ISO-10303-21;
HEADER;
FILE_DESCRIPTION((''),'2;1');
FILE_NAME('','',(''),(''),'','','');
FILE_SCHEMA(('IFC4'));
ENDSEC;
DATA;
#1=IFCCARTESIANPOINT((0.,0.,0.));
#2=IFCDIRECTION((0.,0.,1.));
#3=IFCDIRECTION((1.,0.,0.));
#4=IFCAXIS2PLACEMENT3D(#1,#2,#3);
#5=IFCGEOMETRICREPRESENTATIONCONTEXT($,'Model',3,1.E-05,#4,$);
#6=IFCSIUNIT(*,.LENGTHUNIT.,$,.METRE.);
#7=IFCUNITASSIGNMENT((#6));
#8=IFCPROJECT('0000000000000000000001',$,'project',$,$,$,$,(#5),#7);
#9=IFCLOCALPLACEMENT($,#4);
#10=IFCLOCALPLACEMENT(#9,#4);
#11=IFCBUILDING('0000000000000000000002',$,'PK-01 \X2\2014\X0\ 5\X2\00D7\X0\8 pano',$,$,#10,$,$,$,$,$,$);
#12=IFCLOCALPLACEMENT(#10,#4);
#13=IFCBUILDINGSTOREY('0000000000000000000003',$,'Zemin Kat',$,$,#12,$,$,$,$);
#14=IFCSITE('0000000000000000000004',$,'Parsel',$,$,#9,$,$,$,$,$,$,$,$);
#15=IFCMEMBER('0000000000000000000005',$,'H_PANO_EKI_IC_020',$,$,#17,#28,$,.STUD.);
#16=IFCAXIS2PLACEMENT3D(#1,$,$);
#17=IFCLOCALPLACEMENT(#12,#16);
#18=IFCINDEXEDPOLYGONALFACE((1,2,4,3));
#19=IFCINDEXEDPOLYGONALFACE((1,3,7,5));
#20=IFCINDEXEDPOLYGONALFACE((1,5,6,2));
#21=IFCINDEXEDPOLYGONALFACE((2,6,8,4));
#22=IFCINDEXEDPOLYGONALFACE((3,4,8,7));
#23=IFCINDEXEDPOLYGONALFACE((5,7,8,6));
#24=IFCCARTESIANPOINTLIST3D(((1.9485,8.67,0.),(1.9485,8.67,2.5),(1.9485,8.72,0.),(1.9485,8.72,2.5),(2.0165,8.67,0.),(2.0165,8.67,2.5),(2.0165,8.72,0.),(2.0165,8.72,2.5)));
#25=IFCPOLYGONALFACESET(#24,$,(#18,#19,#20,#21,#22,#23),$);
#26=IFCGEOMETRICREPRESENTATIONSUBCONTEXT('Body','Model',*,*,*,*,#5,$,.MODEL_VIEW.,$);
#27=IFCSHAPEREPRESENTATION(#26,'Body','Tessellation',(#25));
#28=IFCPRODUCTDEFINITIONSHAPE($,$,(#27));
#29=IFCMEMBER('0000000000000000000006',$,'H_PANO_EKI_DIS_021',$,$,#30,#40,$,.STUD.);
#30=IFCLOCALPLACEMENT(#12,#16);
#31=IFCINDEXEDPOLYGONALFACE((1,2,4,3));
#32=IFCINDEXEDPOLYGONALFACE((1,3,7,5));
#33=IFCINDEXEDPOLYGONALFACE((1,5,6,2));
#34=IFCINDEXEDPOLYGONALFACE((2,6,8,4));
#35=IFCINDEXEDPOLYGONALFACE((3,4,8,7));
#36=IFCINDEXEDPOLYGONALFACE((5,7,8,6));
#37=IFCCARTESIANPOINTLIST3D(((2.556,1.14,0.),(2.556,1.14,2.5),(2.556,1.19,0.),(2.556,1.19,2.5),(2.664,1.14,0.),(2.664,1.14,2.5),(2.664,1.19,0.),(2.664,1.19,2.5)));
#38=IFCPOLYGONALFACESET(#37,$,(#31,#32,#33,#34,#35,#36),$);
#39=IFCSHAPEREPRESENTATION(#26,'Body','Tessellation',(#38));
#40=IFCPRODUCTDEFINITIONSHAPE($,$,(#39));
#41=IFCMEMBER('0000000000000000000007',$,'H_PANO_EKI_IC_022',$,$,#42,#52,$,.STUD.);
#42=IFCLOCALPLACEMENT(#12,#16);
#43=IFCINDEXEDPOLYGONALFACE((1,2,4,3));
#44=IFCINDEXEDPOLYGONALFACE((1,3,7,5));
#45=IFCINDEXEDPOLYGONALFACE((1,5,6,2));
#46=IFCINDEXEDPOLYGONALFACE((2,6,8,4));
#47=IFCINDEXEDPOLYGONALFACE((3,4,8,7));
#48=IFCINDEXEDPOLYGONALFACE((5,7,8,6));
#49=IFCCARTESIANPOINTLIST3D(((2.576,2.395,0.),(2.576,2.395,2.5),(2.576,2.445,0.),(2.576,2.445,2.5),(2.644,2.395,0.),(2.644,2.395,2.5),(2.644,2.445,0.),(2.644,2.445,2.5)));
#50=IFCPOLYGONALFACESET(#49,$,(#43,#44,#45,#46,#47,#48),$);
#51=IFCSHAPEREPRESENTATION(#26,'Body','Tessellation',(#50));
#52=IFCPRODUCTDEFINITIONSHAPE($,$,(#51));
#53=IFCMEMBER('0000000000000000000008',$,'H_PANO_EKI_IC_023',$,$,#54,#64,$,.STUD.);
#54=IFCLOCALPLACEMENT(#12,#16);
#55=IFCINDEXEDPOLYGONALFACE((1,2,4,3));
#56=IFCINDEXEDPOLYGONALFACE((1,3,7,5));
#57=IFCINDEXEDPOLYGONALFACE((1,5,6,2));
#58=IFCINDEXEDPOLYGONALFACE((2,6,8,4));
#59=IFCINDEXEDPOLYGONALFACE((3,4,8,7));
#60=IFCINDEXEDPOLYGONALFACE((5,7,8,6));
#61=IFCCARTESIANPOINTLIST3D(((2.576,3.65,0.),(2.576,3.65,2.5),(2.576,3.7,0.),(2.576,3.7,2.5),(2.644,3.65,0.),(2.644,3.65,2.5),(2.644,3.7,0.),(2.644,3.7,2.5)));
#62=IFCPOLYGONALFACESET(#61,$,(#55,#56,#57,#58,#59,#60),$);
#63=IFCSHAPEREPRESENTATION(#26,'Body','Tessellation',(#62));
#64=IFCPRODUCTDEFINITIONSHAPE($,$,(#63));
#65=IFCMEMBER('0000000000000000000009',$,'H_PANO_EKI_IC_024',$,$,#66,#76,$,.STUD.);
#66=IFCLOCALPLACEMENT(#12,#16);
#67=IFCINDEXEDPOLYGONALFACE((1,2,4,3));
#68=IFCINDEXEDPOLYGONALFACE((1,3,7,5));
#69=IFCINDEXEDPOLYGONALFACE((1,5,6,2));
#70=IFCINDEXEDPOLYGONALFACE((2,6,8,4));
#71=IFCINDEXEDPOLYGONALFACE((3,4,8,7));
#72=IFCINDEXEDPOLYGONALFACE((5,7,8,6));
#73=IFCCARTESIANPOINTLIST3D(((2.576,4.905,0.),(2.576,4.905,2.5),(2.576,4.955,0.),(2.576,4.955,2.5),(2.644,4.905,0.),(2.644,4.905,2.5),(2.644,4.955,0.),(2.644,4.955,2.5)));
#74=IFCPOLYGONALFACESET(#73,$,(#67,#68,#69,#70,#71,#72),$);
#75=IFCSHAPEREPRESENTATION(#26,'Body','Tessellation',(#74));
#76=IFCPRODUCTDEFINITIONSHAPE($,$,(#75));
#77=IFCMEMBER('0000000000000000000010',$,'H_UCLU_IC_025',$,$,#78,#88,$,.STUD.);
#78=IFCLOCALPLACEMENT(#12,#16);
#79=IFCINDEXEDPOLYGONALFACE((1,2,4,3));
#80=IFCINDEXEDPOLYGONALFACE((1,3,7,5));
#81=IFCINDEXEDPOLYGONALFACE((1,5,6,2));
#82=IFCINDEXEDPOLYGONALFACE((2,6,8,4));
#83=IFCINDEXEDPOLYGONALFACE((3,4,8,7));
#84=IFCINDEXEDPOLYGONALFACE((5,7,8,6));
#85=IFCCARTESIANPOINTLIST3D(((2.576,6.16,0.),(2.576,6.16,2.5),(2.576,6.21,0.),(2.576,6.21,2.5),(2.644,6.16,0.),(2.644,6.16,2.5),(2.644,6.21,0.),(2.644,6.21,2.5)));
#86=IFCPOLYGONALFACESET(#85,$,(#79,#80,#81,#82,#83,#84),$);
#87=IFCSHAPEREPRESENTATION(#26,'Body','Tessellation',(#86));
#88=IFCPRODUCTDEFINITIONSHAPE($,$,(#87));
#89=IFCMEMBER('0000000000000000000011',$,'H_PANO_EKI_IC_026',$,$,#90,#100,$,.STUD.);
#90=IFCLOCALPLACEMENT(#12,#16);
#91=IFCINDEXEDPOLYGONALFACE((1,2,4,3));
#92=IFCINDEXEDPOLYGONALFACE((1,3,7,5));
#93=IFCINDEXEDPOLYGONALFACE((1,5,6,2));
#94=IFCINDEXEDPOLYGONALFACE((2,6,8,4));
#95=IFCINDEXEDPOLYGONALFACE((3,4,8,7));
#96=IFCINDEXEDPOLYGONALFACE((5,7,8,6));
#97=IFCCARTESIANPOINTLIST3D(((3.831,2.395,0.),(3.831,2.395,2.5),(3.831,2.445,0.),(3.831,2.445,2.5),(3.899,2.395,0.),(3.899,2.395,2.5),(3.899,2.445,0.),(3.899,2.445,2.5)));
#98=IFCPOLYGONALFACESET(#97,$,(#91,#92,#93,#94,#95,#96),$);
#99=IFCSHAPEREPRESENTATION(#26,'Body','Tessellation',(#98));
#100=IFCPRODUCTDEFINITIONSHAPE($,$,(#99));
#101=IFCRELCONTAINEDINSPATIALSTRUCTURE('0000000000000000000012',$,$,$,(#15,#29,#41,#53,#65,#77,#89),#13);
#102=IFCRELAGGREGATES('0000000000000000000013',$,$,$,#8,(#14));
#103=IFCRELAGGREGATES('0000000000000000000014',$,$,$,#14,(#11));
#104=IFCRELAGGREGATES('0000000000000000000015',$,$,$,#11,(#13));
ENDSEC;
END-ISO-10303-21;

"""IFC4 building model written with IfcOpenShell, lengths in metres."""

from ifc_helpers import new_model, si_unit, origin_with_axes, place, context, subcontext, project, spatial, line, indexed_curve, outline, extrude, element, save


model = new_model("IFC4")

# Units and contexts
model_context = context("Model", 3, precision=1e-05, world=origin_with_axes())
body_context = subcontext(model_context, "Body", "Model", "MODEL_VIEW")
ifc_project = project(units=[si_unit("LENGTHUNIT", "METRE")], contexts=[model_context])

# Site, building, storey
site_placement = place(None, origin_with_axes())
site = spatial("IfcSite", under=ifc_project, at=site_placement, Name="Parsel")
building_placement = place(site_placement, origin_with_axes())
building = spatial("IfcBuilding", under=site, at=building_placement, Name="PK-01 — 5×8 pano")
storey_placement = place(building_placement, origin_with_axes())
storey = spatial("IfcBuildingStorey", under=building, at=storey_placement, Name="Zemin Kat")

# Members
member_1_placement = place(storey_placement, origin_with_axes())
element("IfcMember", 1, at=member_1_placement, inside=storey, Name="H_PANO_EKI_IC_020", PredefinedType="STUD", context=body_context, shape_type="SweptSolid", body=[
    extrude(outline(indexed_curve([(1.9485, 8.67), (2.0165, 8.67), (2.0165, 8.72), (1.9485, 8.72)], segments=[line(1, 2, 3, 4, 1)])), origin_with_axes(), (0.0, 0.0, 1.0), 2.5),
])
member_2_placement = place(storey_placement, origin_with_axes())
element("IfcMember", 2, at=member_2_placement, inside=storey, Name="H_PANO_EKI_DIS_021", PredefinedType="STUD", context=body_context, shape_type="SweptSolid", body=[
    extrude(outline(indexed_curve([(2.556, 1.14), (2.664, 1.14), (2.664, 1.19), (2.556, 1.19)], segments=[line(1, 2, 3, 4, 1)])), origin_with_axes(), (0.0, 0.0, 1.0), 2.5),
])
member_3_placement = place(storey_placement, origin_with_axes())
element("IfcMember", 3, at=member_3_placement, inside=storey, Name="H_PANO_EKI_IC_022", PredefinedType="STUD", context=body_context, shape_type="SweptSolid", body=[
    extrude(outline(indexed_curve([(2.576, 2.395), (2.644, 2.395), (2.644, 2.445), (2.576, 2.445)], segments=[line(1, 2, 3, 4, 1)])), origin_with_axes(), (0.0, 0.0, 1.0), 2.5),
])
member_4_placement = place(storey_placement, origin_with_axes())
element("IfcMember", 4, at=member_4_placement, inside=storey, Name="H_PANO_EKI_IC_023", PredefinedType="STUD", context=body_context, shape_type="SweptSolid", body=[
    extrude(outline(indexed_curve([(2.576, 3.65), (2.644, 3.65), (2.644, 3.7), (2.576, 3.7)], segments=[line(1, 2, 3, 4, 1)])), origin_with_axes(), (0.0, 0.0, 1.0), 2.5),
])
member_5_placement = place(storey_placement, origin_with_axes())
element("IfcMember", 5, at=member_5_placement, inside=storey, Name="H_PANO_EKI_IC_024", PredefinedType="STUD", context=body_context, shape_type="SweptSolid", body=[
    extrude(outline(indexed_curve([(2.576, 4.905), (2.644, 4.905), (2.644, 4.955), (2.576, 4.955)], segments=[line(1, 2, 3, 4, 1)])), origin_with_axes(), (0.0, 0.0, 1.0), 2.5),
])
member_6_placement = place(storey_placement, origin_with_axes())
element("IfcMember", 6, at=member_6_placement, inside=storey, Name="H_UCLU_IC_025", PredefinedType="STUD", context=body_context, shape_type="SweptSolid", body=[
    extrude(outline(indexed_curve([(2.576, 6.16), (2.644, 6.16), (2.644, 6.21), (2.576, 6.21)], segments=[line(1, 2, 3, 4, 1)])), origin_with_axes(), (0.0, 0.0, 1.0), 2.5),
])
member_7_placement = place(storey_placement, origin_with_axes())
element("IfcMember", 7, at=member_7_placement, inside=storey, Name="H_PANO_EKI_IC_026", PredefinedType="STUD", context=body_context, shape_type="SweptSolid", body=[
    extrude(outline(indexed_curve([(3.831, 2.395), (3.899, 2.395), (3.899, 2.445), (3.831, 2.445)], segments=[line(1, 2, 3, 4, 1)])), origin_with_axes(), (0.0, 0.0, 1.0), 2.5),
])

save(model, "model.ifc")
